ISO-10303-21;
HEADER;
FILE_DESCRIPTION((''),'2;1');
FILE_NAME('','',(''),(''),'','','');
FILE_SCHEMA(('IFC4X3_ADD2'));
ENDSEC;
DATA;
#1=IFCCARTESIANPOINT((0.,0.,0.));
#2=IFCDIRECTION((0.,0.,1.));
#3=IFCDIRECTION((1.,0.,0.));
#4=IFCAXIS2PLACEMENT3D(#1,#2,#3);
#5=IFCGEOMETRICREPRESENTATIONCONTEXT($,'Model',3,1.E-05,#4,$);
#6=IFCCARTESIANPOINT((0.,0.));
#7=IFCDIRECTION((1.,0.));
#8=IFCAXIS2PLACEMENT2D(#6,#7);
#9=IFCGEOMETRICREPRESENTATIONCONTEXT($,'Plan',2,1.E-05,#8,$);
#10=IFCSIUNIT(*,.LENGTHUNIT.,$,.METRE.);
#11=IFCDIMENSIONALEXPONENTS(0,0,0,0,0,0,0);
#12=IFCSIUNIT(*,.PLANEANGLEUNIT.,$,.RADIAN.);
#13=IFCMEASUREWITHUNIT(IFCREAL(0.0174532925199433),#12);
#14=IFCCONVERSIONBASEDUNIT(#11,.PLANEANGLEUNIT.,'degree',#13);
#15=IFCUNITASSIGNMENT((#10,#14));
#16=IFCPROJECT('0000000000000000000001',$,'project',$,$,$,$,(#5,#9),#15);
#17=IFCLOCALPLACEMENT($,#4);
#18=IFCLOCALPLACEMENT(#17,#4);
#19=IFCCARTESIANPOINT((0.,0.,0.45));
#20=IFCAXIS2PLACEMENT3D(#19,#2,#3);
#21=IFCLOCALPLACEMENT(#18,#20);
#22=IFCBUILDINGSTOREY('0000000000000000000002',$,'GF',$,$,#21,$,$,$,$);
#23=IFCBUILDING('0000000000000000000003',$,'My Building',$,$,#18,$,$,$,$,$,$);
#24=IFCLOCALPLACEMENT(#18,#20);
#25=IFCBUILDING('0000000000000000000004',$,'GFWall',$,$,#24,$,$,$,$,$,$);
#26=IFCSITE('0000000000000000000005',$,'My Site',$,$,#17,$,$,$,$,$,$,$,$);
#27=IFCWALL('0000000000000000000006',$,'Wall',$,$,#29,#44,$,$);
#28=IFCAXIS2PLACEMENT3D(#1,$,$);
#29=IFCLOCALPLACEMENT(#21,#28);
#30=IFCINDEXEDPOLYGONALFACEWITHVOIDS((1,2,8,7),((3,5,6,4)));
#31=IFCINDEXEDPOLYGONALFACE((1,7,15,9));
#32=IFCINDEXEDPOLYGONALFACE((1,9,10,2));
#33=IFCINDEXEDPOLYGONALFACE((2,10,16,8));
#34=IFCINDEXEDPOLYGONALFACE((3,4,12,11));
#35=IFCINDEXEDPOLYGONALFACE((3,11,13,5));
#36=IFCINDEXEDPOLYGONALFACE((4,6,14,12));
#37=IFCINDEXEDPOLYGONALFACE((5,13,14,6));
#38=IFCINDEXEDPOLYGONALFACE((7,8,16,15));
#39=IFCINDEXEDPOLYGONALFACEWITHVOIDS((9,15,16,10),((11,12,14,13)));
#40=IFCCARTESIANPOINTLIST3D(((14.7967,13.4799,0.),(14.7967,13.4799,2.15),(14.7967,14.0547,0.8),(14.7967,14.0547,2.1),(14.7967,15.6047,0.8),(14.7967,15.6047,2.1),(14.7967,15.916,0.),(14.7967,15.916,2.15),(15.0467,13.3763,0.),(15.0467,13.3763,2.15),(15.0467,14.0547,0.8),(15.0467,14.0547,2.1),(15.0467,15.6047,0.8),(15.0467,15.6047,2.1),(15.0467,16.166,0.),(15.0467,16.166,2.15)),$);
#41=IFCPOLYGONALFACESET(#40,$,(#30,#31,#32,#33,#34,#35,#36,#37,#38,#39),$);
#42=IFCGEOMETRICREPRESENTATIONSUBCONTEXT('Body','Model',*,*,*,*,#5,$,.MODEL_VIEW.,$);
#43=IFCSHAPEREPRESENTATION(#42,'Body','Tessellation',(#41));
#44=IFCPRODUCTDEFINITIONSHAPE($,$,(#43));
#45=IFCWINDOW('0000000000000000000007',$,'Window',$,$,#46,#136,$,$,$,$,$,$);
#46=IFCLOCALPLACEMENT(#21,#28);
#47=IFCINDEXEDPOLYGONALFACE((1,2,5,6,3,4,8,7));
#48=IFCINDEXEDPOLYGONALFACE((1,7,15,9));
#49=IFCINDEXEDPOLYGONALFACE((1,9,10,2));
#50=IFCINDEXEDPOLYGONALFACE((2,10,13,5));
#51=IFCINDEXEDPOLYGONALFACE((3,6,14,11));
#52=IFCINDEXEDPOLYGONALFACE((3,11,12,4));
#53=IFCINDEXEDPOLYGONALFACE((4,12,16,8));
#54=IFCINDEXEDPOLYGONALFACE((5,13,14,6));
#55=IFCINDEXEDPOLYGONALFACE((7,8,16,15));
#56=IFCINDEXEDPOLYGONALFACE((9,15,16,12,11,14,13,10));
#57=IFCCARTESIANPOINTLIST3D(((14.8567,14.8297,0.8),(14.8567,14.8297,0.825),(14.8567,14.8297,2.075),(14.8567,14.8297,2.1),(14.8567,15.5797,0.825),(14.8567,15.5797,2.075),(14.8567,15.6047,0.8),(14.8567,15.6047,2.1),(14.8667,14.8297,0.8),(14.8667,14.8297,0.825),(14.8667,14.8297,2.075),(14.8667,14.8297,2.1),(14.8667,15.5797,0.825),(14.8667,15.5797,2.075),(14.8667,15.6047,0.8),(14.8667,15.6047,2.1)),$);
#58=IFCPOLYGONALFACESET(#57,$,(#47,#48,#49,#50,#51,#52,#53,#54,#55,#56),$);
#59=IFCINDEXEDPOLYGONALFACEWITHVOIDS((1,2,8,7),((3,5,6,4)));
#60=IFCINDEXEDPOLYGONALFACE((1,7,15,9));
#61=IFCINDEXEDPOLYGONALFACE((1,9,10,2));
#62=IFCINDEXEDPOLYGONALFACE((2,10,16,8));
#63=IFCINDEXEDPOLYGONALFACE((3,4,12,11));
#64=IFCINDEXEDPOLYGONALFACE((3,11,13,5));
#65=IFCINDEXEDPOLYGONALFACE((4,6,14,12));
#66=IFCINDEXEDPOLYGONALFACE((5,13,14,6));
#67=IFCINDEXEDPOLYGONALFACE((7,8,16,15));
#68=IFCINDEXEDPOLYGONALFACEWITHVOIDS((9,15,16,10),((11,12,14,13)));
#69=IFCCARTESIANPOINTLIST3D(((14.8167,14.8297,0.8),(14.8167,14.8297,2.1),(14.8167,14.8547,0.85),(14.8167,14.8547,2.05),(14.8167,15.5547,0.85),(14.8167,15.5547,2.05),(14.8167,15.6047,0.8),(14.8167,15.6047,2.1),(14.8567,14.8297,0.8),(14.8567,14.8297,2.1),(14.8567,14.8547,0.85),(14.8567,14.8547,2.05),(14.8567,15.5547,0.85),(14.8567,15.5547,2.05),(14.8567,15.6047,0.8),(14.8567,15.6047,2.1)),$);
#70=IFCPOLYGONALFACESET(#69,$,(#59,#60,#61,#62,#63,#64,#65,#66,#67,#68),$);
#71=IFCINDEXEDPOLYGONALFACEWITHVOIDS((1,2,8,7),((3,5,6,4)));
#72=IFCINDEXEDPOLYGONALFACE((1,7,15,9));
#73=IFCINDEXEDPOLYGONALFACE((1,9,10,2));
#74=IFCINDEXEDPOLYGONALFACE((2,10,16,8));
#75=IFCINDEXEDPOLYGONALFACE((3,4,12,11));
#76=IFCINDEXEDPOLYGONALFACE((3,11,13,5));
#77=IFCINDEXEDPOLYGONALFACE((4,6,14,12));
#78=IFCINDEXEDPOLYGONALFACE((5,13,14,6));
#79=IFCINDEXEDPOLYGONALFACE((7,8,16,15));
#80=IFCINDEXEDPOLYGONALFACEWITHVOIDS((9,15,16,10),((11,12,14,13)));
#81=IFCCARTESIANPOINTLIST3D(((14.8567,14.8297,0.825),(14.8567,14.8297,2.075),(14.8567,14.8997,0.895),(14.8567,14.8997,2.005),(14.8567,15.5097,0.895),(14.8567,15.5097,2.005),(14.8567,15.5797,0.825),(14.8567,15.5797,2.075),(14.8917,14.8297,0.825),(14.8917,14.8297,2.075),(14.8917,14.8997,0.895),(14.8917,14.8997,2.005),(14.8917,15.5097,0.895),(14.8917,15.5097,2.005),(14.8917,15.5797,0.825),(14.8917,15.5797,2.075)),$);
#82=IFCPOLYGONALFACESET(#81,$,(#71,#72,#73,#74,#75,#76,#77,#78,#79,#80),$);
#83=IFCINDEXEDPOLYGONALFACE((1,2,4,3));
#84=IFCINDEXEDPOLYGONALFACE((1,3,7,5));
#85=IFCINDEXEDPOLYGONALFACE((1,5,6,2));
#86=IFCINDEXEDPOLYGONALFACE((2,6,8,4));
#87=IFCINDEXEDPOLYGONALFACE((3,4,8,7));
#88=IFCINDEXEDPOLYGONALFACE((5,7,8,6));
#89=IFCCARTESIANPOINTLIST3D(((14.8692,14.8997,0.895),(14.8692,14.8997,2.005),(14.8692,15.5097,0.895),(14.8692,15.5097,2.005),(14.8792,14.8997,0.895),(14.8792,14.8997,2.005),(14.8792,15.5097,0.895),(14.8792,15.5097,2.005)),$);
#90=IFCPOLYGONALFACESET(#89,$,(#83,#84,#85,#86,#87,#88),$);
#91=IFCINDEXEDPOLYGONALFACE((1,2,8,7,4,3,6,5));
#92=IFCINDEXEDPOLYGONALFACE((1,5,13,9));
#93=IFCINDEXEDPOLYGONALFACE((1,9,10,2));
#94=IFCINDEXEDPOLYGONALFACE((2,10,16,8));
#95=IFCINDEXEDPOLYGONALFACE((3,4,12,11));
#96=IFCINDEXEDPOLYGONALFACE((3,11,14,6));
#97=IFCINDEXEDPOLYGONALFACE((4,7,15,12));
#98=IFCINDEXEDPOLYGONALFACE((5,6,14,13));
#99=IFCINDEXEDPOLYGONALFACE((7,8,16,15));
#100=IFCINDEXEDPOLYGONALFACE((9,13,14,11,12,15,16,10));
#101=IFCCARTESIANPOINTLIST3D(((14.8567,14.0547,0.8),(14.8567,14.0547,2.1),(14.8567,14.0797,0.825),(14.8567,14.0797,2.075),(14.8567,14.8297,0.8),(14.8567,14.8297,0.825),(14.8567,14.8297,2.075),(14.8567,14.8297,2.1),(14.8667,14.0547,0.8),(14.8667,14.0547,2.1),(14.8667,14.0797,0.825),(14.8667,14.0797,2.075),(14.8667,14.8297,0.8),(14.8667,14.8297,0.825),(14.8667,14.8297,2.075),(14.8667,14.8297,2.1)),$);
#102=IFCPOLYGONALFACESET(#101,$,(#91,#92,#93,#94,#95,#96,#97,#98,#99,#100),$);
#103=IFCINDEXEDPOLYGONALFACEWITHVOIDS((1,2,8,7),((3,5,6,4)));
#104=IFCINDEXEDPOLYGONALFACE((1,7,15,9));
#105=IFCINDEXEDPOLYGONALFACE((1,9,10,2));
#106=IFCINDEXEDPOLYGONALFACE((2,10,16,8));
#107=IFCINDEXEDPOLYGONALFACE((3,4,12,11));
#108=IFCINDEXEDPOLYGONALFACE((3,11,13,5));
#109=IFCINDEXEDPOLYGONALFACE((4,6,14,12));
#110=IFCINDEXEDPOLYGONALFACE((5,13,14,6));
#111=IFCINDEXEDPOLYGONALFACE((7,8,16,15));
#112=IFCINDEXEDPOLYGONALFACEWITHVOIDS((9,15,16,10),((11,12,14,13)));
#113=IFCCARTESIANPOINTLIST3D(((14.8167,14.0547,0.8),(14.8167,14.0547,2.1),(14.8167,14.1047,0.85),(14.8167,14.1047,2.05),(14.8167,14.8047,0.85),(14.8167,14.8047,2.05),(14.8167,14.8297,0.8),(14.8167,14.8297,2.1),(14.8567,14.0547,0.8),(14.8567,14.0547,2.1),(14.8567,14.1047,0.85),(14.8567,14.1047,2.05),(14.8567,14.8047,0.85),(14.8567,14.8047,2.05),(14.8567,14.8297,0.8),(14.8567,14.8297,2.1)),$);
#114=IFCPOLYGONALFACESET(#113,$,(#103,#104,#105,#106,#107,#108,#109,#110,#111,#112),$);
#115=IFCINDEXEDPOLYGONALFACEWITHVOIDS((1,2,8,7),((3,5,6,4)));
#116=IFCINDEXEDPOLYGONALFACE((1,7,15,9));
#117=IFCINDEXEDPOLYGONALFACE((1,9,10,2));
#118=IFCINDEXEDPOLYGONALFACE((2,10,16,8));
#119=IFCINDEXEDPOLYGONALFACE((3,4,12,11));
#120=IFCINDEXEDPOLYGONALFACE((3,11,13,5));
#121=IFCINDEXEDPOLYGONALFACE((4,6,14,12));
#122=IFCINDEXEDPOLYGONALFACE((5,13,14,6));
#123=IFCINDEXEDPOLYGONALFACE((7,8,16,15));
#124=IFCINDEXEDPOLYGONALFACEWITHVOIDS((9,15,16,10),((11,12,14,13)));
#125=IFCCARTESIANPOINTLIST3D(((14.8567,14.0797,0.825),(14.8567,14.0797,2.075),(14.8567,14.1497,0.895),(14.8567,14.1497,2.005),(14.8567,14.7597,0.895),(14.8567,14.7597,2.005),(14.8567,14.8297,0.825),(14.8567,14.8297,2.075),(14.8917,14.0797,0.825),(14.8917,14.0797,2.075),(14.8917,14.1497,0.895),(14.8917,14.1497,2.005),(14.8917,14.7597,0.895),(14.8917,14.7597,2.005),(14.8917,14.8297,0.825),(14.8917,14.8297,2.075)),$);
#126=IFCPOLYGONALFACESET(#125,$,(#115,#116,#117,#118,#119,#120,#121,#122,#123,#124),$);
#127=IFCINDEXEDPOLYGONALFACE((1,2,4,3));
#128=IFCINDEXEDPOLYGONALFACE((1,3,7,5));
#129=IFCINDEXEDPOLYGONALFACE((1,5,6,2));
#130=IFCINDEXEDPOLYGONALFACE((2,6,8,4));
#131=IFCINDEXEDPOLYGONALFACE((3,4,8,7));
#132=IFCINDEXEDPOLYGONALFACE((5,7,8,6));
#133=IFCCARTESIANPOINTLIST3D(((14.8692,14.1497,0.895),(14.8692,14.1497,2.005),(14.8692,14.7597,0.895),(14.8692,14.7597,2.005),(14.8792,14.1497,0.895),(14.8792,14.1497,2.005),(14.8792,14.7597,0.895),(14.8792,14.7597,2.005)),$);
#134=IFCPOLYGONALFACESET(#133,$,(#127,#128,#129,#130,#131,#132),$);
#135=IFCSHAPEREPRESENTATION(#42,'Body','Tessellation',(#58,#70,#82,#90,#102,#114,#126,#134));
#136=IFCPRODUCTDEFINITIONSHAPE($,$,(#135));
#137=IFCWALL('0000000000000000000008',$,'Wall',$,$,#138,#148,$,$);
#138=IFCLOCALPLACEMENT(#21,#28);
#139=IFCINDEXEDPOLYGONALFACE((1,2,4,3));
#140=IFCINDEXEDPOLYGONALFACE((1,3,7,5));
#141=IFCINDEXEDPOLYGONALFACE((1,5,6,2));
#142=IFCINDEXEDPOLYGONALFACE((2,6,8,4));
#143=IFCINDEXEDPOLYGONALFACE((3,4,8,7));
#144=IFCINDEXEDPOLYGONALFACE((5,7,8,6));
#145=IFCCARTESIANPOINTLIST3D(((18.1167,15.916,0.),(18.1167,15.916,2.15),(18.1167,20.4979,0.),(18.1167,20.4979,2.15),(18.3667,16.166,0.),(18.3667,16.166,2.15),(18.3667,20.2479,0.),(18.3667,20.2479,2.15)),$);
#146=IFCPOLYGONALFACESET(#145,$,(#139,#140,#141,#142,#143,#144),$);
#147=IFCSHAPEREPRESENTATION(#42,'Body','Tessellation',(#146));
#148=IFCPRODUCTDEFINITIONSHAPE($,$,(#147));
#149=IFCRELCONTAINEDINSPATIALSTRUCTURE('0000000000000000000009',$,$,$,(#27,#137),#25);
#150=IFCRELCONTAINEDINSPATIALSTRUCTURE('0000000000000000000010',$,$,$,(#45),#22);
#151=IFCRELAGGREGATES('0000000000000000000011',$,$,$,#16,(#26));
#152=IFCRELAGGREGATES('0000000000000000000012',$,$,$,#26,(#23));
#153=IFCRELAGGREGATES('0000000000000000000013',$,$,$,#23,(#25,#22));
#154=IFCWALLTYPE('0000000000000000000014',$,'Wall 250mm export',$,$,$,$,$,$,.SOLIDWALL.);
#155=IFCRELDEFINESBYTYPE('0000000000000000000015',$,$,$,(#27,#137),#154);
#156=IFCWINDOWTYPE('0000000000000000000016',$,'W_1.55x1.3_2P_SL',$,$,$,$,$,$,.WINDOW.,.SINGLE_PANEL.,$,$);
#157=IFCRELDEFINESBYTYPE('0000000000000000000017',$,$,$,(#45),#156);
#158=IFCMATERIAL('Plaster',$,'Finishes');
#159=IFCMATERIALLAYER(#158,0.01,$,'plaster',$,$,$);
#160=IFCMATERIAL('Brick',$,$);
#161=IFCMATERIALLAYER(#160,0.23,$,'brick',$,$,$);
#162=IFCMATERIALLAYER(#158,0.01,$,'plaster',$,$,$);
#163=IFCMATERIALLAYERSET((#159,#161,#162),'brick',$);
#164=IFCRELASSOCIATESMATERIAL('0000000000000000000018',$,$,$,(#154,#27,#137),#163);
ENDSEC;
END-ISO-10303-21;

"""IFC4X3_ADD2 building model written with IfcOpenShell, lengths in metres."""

from ifc_helpers import new_model, entity, si_unit, converted_unit, frame, origin_with_axes, origin_2d_with_axis, place, context, subcontext, project, spatial, line, indexed_curve, outline, extrude, shape, source, transform, mapped, material, layer, layer_set, layer_usage, type_object, type_shapes, element, fill, save


model = new_model("IFC4X3_ADD2")

# Units and contexts
model_context = context("Model", 3, precision=1e-05, world=origin_with_axes())
plan_context = context("Plan", 2, precision=1e-05, world=origin_2d_with_axis())
body_context_1 = subcontext(model_context, "Body", "Model", "MODEL_VIEW")
body_context_2 = subcontext(plan_context, "Body", "Plan", "PLAN_VIEW")
ifc_project = project(units=[si_unit("LENGTHUNIT", "METRE"), converted_unit("PLANEANGLEUNIT", "degree", entity("IfcReal", 0.0174532925199433), si_unit("PLANEANGLEUNIT", "RADIAN"), dimensions=[0, 0, 0, 0, 0, 0, 0])], contexts=[model_context, plan_context])

# Site, buildings
site_placement = place(None, origin_with_axes())
site = spatial("IfcSite", under=ifc_project, at=site_placement, Name="My Site")
building_1_placement = place(site_placement, origin_with_axes())
building_1 = spatial("IfcBuilding", under=site, at=building_1_placement, Name="My Building")
building_2_placement = place(building_1_placement, frame((0.0, 0.0, 0.45), z_axis=(0.0, 0.0, 1.0), x_axis=(1.0, 0.0, 0.0)))
building_2 = spatial("IfcBuilding", under=building_1, at=building_2_placement, Name="GFWall")

# Shared definitions
shared_shape_1 = source(origin_with_axes(), body_context_1, "Body", "SweptSolid", [
    extrude(outline(indexed_curve([(0.0, 0.0), (1.55, 0.0), (1.55, 1.3), (0.0, 1.3)], segments=[line(1, 2, 3, 4, 1)])), frame((0.0, -0.6, 0.0), z_axis=(0.0, -1.0, 0.0), x_axis=(1.0, 0.0, 0.0)), (0.0, 0.0, -1.0), 1.2),
])

# Shared definitions
storey_placement = place(building_1_placement, frame((0.0, 0.0, 0.45), z_axis=(0.0, 0.0, 1.0), x_axis=(1.0, 0.0, 0.0)))
storey = spatial("IfcBuildingStorey", under=building_1, at=storey_placement, Name="GF")

# Shared definitions
window_type_1 = type_object("IfcWindowType", Name="W_1.55x1.3_2P_SL", PartitioningType="SINGLE_PANEL", PredefinedType="WINDOW")
shared_shape_2 = source(origin_with_axes(), body_context_1, "Body", "SweptSolid", [
    extrude(outline(indexed_curve([(0.775, 0.0), (0.0, 0.0), (0.0, 1.3), (0.775, 1.3), (0.775, 1.275), (0.025, 1.275), (0.025, 0.025), (0.775, 0.025)], segments=[line(1, 2, 3, 4, 5, 6, 7, 8, 1)])), frame((0.0, 0.09, 0.0), z_axis=(0.0, -1.0, 0.0), x_axis=(1.0, 0.0, 0.0)), (0.0, 0.0, -1.0), 0.01),
    extrude(outline(indexed_curve([(0.0, 0.0), (0.775, 0.0), (0.775, 1.3), (0.0, 1.3)], segments=[line(1, 2, 3, 4, 1)]), holes=[indexed_curve([(0.05, 0.05), (0.75, 0.05), (0.75, 1.25), (0.05, 1.25)], segments=[line(1, 2, 3, 4, 1)])]), frame((0.0, 0.05, 0.0), z_axis=(0.0, -1.0, 0.0), x_axis=(1.0, 0.0, 0.0)), (0.0, 0.0, -1.0), 0.04),
    extrude(outline(indexed_curve([(0.0, 0.0), (0.75, 0.0), (0.75, 1.25), (0.0, 1.25)], segments=[line(1, 2, 3, 4, 1)]), holes=[indexed_curve([(0.07, 0.07), (0.68, 0.07), (0.68, 1.18), (0.07, 1.18)], segments=[line(1, 2, 3, 4, 1)])]), frame((0.025, 0.09, 0.025), z_axis=(0.0, -1.0, 0.0), x_axis=(1.0, 0.0, 0.0)), (0.0, 0.0, -1.0), 0.035),
    extrude(outline(indexed_curve([(0.07, 0.07), (0.68, 0.07), (0.68, 1.18), (0.07, 1.18)], segments=[line(1, 2, 3, 4, 1)])), frame((0.025, 0.1025, 0.025), z_axis=(0.0, -1.0, 0.0), x_axis=(1.0, 0.0, 0.0)), (0.0, 0.0, -1.0), 0.01),
    extrude(outline(indexed_curve([(0.0, 1.3), (0.775, 1.3), (0.775, 0.0), (0.0, 0.0), (0.0, 0.025), (0.75, 0.025), (0.75, 1.275), (0.0, 1.275)], segments=[line(1, 2, 3, 4, 5, 6, 7, 8, 1)])), frame((0.775, 0.09, 0.0), z_axis=(0.0, -1.0, 0.0), x_axis=(1.0, 0.0, 0.0)), (0.0, 0.0, -1.0), 0.01),
    extrude(outline(indexed_curve([(0.0, 0.0), (0.775, 0.0), (0.775, 1.3), (0.0, 1.3)], segments=[line(1, 2, 3, 4, 1)]), holes=[indexed_curve([(0.025, 0.05), (0.725, 0.05), (0.725, 1.25), (0.025, 1.25)], segments=[line(1, 2, 3, 4, 1)])]), frame((0.775, 0.05, 0.0), z_axis=(0.0, -1.0, 0.0), x_axis=(1.0, 0.0, 0.0)), (0.0, 0.0, -1.0), 0.04),
    extrude(outline(indexed_curve([(0.0, 0.0), (0.75, 0.0), (0.75, 1.25), (0.0, 1.25)], segments=[line(1, 2, 3, 4, 1)]), holes=[indexed_curve([(0.07, 0.07), (0.68, 0.07), (0.68, 1.18), (0.07, 1.18)], segments=[line(1, 2, 3, 4, 1)])]), frame((0.775, 0.09, 0.025), z_axis=(0.0, -1.0, 0.0), x_axis=(1.0, 0.0, 0.0)), (0.0, 0.0, -1.0), 0.035),
    extrude(outline(indexed_curve([(0.07, 0.07), (0.68, 0.07), (0.68, 1.18), (0.07, 1.18)], segments=[line(1, 2, 3, 4, 1)])), frame((0.775, 0.1025, 0.025), z_axis=(0.0, -1.0, 0.0), x_axis=(1.0, 0.0, 0.0)), (0.0, 0.0, -1.0), 0.01),
])
shared_shape_3 = source(origin_with_axes(), body_context_2, "Body", "Curve2D", [
    entity("IfcIndexedPolyCurve", entity("IfcCartesianPointList2D", [[0.05, 0.05], [0.75, 0.05]])),
    entity("IfcIndexedPolyCurve", entity("IfcCartesianPointList2D", [[0.0, 0.1], [0.025, 0.1], [0.025, 0.09], [0.05, 0.09], [0.05, 0.05], [0.0, 0.05]]), [entity("IfcLineIndex", [1, 2, 3, 4, 5, 6, 1])]),
    entity("IfcIndexedPolyCurve", entity("IfcCartesianPointList2D", [[0.775, 0.1], [0.775, 0.1], [0.775, 0.09], [0.75, 0.09], [0.75, 0.05], [0.775, 0.05]])),
    entity("IfcIndexedPolyCurve", entity("IfcCartesianPointList2D", [[0.025, 0.09], [0.095, 0.09], [0.095, 0.125], [0.025, 0.125]]), [entity("IfcLineIndex", [1, 2, 3, 4, 1])]),
    entity("IfcIndexedPolyCurve", entity("IfcCartesianPointList2D", [[0.775, 0.09], [0.705, 0.09], [0.705, 0.125], [0.775, 0.125]]), [entity("IfcLineIndex", [1, 2, 3, 4, 1])]),
    entity("IfcIndexedPolyCurve", entity("IfcCartesianPointList2D", [[0.095, 0.09], [0.705, 0.09]])),
    entity("IfcIndexedPolyCurve", entity("IfcCartesianPointList2D", [[0.095, 0.125], [0.705, 0.125]])),
    entity("IfcIndexedPolyCurve", entity("IfcCartesianPointList2D", [[0.095, 0.1075], [0.705, 0.1075]])),
    entity("IfcIndexedPolyCurve", entity("IfcCartesianPointList2D", [[0.8, 0.05], [1.5, 0.05]])),
    entity("IfcIndexedPolyCurve", entity("IfcCartesianPointList2D", [[0.775, 0.1], [0.775, 0.1], [0.775, 0.09], [0.8, 0.09], [0.8, 0.05], [0.775, 0.05]])),
    entity("IfcIndexedPolyCurve", entity("IfcCartesianPointList2D", [[1.55, 0.1], [1.525, 0.1], [1.525, 0.09], [1.5, 0.09], [1.5, 0.05], [1.55, 0.05]]), [entity("IfcLineIndex", [1, 2, 3, 4, 5, 6, 1])]),
    entity("IfcIndexedPolyCurve", entity("IfcCartesianPointList2D", [[0.775, 0.09], [0.845, 0.09], [0.845, 0.125], [0.775, 0.125]]), [entity("IfcLineIndex", [1, 2, 3, 4, 1])]),
    entity("IfcIndexedPolyCurve", entity("IfcCartesianPointList2D", [[1.525, 0.09], [1.455, 0.09], [1.455, 0.125], [1.525, 0.125]]), [entity("IfcLineIndex", [1, 2, 3, 4, 1])]),
    entity("IfcIndexedPolyCurve", entity("IfcCartesianPointList2D", [[0.845, 0.09], [1.455, 0.09]])),
    entity("IfcIndexedPolyCurve", entity("IfcCartesianPointList2D", [[0.845, 0.125], [1.455, 0.125]])),
    entity("IfcIndexedPolyCurve", entity("IfcCartesianPointList2D", [[0.845, 0.1075], [1.455, 0.1075]])),
])
type_shapes(window_type_1, [shared_shape_2, shared_shape_3])

# Shared definitions
ifc_material_1 = material(Name="Plaster", Category="Finishes")

# Wall, opening, window
ifc_layer_1 = layer(ifc_material_1, 0.01, Name="plaster")
ifc_material_2 = material(Name="Brick")
ifc_layer_2 = layer(ifc_material_2, 0.23, Name="brick")
ifc_layer_3 = layer(ifc_material_1, 0.01, Name="plaster")
ifc_layer_set_1 = layer_set([ifc_layer_1, ifc_layer_2, ifc_layer_3], Name="brick")
wall_type_1 = type_object("IfcWallType", Name="Wall 250mm export", PredefinedType="SOLIDWALL", material=ifc_layer_set_1)
ifc_layer_usage_1 = layer_usage(ifc_layer_set_1, "AXIS2", "POSITIVE", 0.0)
wall_1_placement = place(building_2_placement, frame((15.0467, 13.3763, 0.0), z_axis=(0.0, 0.0, 1.0), x_axis=(0.0, 1.0, 0.0)))
wall_1 = element("IfcWall", 1, at=wall_1_placement, inside=building_2, type_object=wall_type_1, material=ifc_layer_usage_1, Name="Wall", context=body_context_1, shape_type="SweptSolid", body=[
    extrude(outline(indexed_curve([(0.0, 0.0), (0.1036, 0.25), (2.5397, 0.25), (2.7897, 0.0)], segments=[line(1, 2, 3, 4, 1)])), origin_with_axes(), (0.0, 0.0, 1.0), 2.15),
])
opening_1_placement = place(wall_1_placement, frame((2.2283, 0.28, 0.8), z_axis=(0.0, 0.0, 1.0), x_axis=(-1.0, 0.0, 0.0)))
opening_1 = element("IfcOpeningElement", 2, at=opening_1_placement, cuts=wall_1, PredefinedType="OPENING", context=body_context_1, shape_type="MappedRepresentation", body=[
    mapped(shared_shape_1, transform((0.0, 0.0, 0.0), x_axis=(1.0, 0.0, 0.0), y_axis=(0.0, 1.0, 0.0), z_axis=(0.0, 0.0, 1.0), scale=1.0)),
])
window_1_placement = place(opening_1_placement, frame((0.0, 0.0, 0.0), z_axis=(0.0, 0.0, 1.0), x_axis=(1.0, 0.0, 0.0)))
window_1 = element("IfcWindow", 3, at=window_1_placement, inside=storey, type_object=window_type_1, Name="Window", shapes=[
    shape(body_context_1, "Body", "MappedRepresentation", [mapped(shared_shape_2, transform((0.0, 0.0, 0.0), x_axis=(1.0, 0.0, 0.0), y_axis=(0.0, 1.0, 0.0), z_axis=(0.0, 0.0, 1.0), scale=1.0))]),
    shape(body_context_2, "Body", "MappedRepresentation", [mapped(shared_shape_3, transform((0.0, 0.0, 0.0), x_axis=(1.0, 0.0, 0.0), y_axis=(0.0, 1.0, 0.0), z_axis=(0.0, 0.0, 1.0), scale=1.0))]),
])
fill(opening_1, window_1)

# Wall
ifc_layer_usage_2 = layer_usage(ifc_layer_set_1, "AXIS2", "NEGATIVE", 0.0)
wall_2_placement = place(building_2_placement, frame((18.1167, 15.916, 0.0), z_axis=(0.0, 0.0, 1.0), x_axis=(0.0, 1.0, 0.0)))
element("IfcWall", 4, at=wall_2_placement, inside=building_2, type_object=wall_type_1, material=ifc_layer_usage_2, Name="Wall", context=body_context_1, shape_type="SweptSolid", body=[
    extrude(outline(indexed_curve([(0.25, -0.25), (0.0, 0.0), (4.5819, 0.0), (4.3319, -0.25)], segments=[line(1, 2, 3, 4, 1)])), origin_with_axes(), (0.0, 0.0, 1.0), 2.15),
])

save(model, "model.ifc")
